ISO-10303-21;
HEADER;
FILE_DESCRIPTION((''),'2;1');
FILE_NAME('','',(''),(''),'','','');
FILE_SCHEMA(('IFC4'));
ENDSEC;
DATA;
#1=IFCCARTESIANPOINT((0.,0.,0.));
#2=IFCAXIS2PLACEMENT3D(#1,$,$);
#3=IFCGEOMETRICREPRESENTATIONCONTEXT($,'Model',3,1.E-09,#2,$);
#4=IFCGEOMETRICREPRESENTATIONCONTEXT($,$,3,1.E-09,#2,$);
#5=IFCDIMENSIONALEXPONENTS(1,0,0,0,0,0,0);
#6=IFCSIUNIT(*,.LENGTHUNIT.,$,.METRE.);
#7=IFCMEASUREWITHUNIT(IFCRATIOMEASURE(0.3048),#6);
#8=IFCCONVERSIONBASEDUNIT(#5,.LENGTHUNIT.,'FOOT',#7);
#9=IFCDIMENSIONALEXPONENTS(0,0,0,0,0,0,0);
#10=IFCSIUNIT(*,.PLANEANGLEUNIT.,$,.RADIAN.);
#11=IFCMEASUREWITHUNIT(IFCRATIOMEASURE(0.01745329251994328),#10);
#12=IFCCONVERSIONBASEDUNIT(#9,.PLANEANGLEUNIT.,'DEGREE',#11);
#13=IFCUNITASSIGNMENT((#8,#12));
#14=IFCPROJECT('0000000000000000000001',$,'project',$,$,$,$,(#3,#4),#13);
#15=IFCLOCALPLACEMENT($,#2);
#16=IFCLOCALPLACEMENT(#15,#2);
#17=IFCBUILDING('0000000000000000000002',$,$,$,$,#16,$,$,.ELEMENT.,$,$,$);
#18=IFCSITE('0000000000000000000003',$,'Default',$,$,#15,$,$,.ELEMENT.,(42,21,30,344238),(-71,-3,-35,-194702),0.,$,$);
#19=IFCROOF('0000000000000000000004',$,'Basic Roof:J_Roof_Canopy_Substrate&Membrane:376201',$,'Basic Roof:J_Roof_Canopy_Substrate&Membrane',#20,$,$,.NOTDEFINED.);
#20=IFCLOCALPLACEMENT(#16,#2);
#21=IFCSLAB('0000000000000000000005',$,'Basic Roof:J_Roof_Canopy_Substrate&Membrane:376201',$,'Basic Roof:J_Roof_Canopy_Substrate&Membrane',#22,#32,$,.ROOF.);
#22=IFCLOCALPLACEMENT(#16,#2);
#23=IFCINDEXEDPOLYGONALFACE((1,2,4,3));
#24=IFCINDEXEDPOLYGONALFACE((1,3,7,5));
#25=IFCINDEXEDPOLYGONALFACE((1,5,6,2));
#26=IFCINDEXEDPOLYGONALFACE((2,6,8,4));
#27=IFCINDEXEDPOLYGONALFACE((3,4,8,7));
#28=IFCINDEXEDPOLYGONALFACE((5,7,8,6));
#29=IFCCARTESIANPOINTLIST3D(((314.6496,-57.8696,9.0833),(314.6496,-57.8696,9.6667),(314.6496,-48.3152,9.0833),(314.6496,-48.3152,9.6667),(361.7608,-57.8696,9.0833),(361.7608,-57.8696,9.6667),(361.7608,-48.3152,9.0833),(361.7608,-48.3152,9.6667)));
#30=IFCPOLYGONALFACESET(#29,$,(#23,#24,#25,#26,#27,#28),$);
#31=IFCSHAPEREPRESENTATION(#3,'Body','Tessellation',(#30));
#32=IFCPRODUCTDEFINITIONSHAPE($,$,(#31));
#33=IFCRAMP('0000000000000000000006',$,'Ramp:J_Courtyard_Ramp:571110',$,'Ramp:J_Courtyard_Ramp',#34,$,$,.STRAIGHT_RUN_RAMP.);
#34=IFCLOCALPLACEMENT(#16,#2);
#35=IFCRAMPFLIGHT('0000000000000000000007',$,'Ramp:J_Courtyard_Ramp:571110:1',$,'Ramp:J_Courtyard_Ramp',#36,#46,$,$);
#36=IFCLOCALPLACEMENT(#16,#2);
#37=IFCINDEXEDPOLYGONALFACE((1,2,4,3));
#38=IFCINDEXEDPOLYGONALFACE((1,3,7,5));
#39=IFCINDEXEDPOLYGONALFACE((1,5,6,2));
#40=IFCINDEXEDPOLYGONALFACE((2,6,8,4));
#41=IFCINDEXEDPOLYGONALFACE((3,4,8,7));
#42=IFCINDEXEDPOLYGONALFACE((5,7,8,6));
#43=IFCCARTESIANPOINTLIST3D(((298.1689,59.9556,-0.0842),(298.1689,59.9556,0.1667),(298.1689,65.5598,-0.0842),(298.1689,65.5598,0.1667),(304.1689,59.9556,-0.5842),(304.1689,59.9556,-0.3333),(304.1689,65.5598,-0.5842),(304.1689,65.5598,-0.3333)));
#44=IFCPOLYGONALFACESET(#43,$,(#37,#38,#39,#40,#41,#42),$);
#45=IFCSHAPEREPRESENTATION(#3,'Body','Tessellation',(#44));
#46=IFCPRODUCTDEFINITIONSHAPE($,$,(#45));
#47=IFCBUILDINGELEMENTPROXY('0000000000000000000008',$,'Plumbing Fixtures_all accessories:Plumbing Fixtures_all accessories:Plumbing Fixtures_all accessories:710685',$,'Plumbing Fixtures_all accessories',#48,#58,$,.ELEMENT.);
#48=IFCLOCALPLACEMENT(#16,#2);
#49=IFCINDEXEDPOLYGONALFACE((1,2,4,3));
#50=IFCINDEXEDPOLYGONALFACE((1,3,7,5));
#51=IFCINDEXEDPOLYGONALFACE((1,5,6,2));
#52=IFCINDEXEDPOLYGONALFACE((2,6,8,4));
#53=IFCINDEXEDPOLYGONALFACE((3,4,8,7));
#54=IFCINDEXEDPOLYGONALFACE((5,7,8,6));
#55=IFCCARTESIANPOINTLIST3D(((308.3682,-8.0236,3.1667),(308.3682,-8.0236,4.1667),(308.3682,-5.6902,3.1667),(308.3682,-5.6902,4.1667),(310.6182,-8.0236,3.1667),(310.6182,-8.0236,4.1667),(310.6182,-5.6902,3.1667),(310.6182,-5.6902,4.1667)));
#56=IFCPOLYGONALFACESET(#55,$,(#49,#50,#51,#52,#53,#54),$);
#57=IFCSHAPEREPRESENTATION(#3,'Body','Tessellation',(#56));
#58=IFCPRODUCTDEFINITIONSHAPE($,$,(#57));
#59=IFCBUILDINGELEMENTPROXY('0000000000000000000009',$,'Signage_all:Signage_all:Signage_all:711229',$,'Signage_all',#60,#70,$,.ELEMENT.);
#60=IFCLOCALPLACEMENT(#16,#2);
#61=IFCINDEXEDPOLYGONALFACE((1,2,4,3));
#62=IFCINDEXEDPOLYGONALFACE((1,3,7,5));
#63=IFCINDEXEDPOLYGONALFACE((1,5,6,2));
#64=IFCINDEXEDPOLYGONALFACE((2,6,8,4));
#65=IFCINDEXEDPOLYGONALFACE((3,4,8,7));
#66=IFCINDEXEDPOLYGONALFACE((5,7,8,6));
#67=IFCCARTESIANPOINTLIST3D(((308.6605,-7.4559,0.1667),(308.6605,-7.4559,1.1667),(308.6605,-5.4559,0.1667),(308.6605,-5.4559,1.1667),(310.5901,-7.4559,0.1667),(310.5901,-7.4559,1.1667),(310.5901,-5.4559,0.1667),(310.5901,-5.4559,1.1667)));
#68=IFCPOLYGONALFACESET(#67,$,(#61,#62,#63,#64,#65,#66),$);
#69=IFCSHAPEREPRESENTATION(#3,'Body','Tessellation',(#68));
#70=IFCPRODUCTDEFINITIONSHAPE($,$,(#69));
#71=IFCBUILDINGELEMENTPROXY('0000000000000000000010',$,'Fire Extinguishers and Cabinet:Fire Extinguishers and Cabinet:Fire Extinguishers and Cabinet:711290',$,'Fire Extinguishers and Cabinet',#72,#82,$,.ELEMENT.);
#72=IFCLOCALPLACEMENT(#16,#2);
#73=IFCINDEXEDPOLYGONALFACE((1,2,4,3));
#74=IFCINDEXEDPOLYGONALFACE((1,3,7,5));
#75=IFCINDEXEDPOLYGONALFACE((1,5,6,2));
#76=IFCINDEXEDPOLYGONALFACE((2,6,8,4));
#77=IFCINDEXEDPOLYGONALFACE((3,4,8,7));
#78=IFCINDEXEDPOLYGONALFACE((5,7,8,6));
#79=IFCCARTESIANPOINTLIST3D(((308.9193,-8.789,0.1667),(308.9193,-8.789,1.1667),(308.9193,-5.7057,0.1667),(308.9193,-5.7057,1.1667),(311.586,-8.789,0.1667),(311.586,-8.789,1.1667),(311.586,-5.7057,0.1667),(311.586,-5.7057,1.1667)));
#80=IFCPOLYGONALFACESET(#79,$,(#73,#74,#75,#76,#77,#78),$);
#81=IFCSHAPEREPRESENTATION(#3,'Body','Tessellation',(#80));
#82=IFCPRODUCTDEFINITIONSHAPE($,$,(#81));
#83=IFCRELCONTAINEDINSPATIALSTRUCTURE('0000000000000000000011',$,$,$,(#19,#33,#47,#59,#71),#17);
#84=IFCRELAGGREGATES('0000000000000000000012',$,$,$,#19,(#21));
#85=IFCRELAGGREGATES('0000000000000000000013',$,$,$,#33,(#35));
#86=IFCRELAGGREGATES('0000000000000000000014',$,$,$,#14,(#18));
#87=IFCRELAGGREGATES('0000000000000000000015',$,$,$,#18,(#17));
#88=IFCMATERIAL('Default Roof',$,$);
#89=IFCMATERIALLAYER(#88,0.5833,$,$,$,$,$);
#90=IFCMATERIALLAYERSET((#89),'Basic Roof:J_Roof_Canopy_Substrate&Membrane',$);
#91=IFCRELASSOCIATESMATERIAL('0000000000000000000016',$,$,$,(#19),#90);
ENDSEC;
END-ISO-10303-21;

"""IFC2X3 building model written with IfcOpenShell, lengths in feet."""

from ifc_helpers import new_model, entity, si_unit, converted_unit, frame, frame_2d, origin, origin_2d_with_axis, place, context, project, spatial, polyline, rectangle, outline, extrude, source, transform, mapped, material, layer, layer_set, layer_usage, element, aggregate, save


model = new_model("IFC2X3")

# Units and contexts
model_context = context("Model", 3, precision=1e-09, world=origin())
context_of_model = context(None, 3, precision=1e-09, world=origin())
ifc_project = project(units=[converted_unit("LENGTHUNIT", "FOOT", entity("IfcRatioMeasure", 0.3048), si_unit("LENGTHUNIT", "METRE"), dimensions=[1, 0, 0, 0, 0, 0, 0]), converted_unit("PLANEANGLEUNIT", "DEGREE", entity("IfcRatioMeasure", 0.01745329251994328), si_unit("PLANEANGLEUNIT", "RADIAN"), dimensions=[0, 0, 0, 0, 0, 0, 0])], contexts=[model_context, context_of_model])

# Site, building
site_placement = place(None, origin())
site = spatial("IfcSite", under=ifc_project, at=site_placement, Name="Default", CompositionType="ELEMENT", RefLatitude=(42, 21, 30, 344238), RefLongitude=(-71, -3, -35, -194702), RefElevation=0.0)
building_placement = place(site_placement, origin())
building = spatial("IfcBuilding", under=site, at=building_placement, CompositionType="ELEMENT")

# Roof, slab
ifc_material_1 = material(Name="Default Roof")
ifc_layer_1 = layer(ifc_material_1, 0.5833)
ifc_layer_set_1 = layer_set([ifc_layer_1], Name="Basic Roof:J_Roof_Canopy_Substrate&Membrane")
ifc_layer_usage_1 = layer_usage(ifc_layer_set_1, "AXIS3", "NEGATIVE", 0.0)
placement = place(building_placement, frame((0.0, 0.0, 0.1667)))
roof_1_placement = place(placement, origin())
roof_1 = element("IfcRoof", 1, at=roof_1_placement, inside=building, material=ifc_layer_usage_1, Name="Basic Roof:J_Roof_Canopy_Substrate&Membrane:376201", ObjectType="Basic Roof:J_Roof_Canopy_Substrate&Membrane", ShapeType="NOTDEFINED")
slab_1_placement = place(roof_1_placement, frame((314.6496, -57.8696, 8.9167)))
slab_1 = element("IfcSlab", 2, at=slab_1_placement, Name="Basic Roof:J_Roof_Canopy_Substrate&Membrane:376201", ObjectType="Basic Roof:J_Roof_Canopy_Substrate&Membrane", PredefinedType="ROOF", context=model_context, shape_type="SweptSolid", body=[
    extrude(rectangle(XDim=47.1112, YDim=9.5543, at=frame_2d((0.0, 0.0), x_axis=(-1.0, 0.0))), frame((23.5556, 4.7772, 0.0)), (0.0, 0.0, 1.0), 0.5833),
])
aggregate(roof_1, [slab_1])

# Ramp, ramp flight
ramp_placement = place(placement, origin())
ramp = element("IfcRamp", 3, at=ramp_placement, inside=building, Name="Ramp:J_Courtyard_Ramp:571110", ObjectType="Ramp:J_Courtyard_Ramp", ShapeType="STRAIGHT_RUN_RAMP")
ramp_flight_placement = place(placement, origin())
ramp_flight = element("IfcRampFlight", 4, at=ramp_flight_placement, Name="Ramp:J_Courtyard_Ramp:571110:1", ObjectType="Ramp:J_Courtyard_Ramp", context=model_context, shape_type="SweptSolid", body=[
    extrude(outline(polyline([(0.1246, -3.0), (0.3754, -3.0), (-0.1246, 3.0), (-0.3754, 3.0), (0.1246, -3.0)])), frame((301.1689, 59.9556, -0.3754), z_axis=(0.0, 1.0, 0.0), x_axis=(0.0, 0.0, -1.0)), (0.0, 0.0, 1.0), 5.6042),
])
aggregate(ramp, [ramp_flight])

# Building element proxies
shared_shape_1 = source(origin(), model_context, "Body", "SweptSolid", [
    extrude(rectangle(XDim=2.25, YDim=2.3333, at=origin_2d_with_axis()), frame((309.4932, -6.8569, 3.1667), z_axis=(0.0, 0.0, 1.0), x_axis=(-1.0, 0.0, 0.0)), (0.0, 0.0, 1.0), 1.0),
])
proxy_1_placement = place(None, origin())
element("IfcBuildingElementProxy", 5, at=proxy_1_placement, inside=building, Name="Plumbing Fixtures_all accessories:Plumbing Fixtures_all accessories:Plumbing Fixtures_all accessories:710685", ObjectType="Plumbing Fixtures_all accessories", CompositionType="ELEMENT", context=model_context, shape_type="MappedRepresentation", body=[
    mapped(shared_shape_1, transform((0.0, 0.0, 0.0), scale=1.0)),
])
shared_shape_2 = source(origin(), model_context, "Body", "SweptSolid", [
    extrude(rectangle(XDim=1.9296, YDim=2.0, at=origin_2d_with_axis()), frame((309.6253, -6.4559, 0.1667), z_axis=(0.0, 0.0, 1.0), x_axis=(-1.0, 0.0, 0.0)), (0.0, 0.0, 1.0), 1.0),
])
proxy_2_placement = place(None, origin())
element("IfcBuildingElementProxy", 6, at=proxy_2_placement, inside=building, Name="Signage_all:Signage_all:Signage_all:711229", ObjectType="Signage_all", CompositionType="ELEMENT", context=model_context, shape_type="MappedRepresentation", body=[
    mapped(shared_shape_2, transform((0.0, 0.0, 0.0), scale=1.0)),
])
shared_shape_3 = source(origin(), model_context, "Body", "SweptSolid", [
    extrude(rectangle(XDim=2.6667, YDim=3.0833, at=origin_2d_with_axis()), frame((310.2527, -7.2474, 0.1667), z_axis=(0.0, 0.0, 1.0), x_axis=(-1.0, 0.0, 0.0)), (0.0, 0.0, 1.0), 1.0),
])
proxy_3_placement = place(None, origin())
element("IfcBuildingElementProxy", 7, at=proxy_3_placement, inside=building, Name="Fire Extinguishers and Cabinet:Fire Extinguishers and Cabinet:Fire Extinguishers and Cabinet:711290", ObjectType="Fire Extinguishers and Cabinet", CompositionType="ELEMENT", context=model_context, shape_type="MappedRepresentation", body=[
    mapped(shared_shape_3, transform((0.0, 0.0, 0.0), scale=1.0)),
])

save(model, "model.ifc")
